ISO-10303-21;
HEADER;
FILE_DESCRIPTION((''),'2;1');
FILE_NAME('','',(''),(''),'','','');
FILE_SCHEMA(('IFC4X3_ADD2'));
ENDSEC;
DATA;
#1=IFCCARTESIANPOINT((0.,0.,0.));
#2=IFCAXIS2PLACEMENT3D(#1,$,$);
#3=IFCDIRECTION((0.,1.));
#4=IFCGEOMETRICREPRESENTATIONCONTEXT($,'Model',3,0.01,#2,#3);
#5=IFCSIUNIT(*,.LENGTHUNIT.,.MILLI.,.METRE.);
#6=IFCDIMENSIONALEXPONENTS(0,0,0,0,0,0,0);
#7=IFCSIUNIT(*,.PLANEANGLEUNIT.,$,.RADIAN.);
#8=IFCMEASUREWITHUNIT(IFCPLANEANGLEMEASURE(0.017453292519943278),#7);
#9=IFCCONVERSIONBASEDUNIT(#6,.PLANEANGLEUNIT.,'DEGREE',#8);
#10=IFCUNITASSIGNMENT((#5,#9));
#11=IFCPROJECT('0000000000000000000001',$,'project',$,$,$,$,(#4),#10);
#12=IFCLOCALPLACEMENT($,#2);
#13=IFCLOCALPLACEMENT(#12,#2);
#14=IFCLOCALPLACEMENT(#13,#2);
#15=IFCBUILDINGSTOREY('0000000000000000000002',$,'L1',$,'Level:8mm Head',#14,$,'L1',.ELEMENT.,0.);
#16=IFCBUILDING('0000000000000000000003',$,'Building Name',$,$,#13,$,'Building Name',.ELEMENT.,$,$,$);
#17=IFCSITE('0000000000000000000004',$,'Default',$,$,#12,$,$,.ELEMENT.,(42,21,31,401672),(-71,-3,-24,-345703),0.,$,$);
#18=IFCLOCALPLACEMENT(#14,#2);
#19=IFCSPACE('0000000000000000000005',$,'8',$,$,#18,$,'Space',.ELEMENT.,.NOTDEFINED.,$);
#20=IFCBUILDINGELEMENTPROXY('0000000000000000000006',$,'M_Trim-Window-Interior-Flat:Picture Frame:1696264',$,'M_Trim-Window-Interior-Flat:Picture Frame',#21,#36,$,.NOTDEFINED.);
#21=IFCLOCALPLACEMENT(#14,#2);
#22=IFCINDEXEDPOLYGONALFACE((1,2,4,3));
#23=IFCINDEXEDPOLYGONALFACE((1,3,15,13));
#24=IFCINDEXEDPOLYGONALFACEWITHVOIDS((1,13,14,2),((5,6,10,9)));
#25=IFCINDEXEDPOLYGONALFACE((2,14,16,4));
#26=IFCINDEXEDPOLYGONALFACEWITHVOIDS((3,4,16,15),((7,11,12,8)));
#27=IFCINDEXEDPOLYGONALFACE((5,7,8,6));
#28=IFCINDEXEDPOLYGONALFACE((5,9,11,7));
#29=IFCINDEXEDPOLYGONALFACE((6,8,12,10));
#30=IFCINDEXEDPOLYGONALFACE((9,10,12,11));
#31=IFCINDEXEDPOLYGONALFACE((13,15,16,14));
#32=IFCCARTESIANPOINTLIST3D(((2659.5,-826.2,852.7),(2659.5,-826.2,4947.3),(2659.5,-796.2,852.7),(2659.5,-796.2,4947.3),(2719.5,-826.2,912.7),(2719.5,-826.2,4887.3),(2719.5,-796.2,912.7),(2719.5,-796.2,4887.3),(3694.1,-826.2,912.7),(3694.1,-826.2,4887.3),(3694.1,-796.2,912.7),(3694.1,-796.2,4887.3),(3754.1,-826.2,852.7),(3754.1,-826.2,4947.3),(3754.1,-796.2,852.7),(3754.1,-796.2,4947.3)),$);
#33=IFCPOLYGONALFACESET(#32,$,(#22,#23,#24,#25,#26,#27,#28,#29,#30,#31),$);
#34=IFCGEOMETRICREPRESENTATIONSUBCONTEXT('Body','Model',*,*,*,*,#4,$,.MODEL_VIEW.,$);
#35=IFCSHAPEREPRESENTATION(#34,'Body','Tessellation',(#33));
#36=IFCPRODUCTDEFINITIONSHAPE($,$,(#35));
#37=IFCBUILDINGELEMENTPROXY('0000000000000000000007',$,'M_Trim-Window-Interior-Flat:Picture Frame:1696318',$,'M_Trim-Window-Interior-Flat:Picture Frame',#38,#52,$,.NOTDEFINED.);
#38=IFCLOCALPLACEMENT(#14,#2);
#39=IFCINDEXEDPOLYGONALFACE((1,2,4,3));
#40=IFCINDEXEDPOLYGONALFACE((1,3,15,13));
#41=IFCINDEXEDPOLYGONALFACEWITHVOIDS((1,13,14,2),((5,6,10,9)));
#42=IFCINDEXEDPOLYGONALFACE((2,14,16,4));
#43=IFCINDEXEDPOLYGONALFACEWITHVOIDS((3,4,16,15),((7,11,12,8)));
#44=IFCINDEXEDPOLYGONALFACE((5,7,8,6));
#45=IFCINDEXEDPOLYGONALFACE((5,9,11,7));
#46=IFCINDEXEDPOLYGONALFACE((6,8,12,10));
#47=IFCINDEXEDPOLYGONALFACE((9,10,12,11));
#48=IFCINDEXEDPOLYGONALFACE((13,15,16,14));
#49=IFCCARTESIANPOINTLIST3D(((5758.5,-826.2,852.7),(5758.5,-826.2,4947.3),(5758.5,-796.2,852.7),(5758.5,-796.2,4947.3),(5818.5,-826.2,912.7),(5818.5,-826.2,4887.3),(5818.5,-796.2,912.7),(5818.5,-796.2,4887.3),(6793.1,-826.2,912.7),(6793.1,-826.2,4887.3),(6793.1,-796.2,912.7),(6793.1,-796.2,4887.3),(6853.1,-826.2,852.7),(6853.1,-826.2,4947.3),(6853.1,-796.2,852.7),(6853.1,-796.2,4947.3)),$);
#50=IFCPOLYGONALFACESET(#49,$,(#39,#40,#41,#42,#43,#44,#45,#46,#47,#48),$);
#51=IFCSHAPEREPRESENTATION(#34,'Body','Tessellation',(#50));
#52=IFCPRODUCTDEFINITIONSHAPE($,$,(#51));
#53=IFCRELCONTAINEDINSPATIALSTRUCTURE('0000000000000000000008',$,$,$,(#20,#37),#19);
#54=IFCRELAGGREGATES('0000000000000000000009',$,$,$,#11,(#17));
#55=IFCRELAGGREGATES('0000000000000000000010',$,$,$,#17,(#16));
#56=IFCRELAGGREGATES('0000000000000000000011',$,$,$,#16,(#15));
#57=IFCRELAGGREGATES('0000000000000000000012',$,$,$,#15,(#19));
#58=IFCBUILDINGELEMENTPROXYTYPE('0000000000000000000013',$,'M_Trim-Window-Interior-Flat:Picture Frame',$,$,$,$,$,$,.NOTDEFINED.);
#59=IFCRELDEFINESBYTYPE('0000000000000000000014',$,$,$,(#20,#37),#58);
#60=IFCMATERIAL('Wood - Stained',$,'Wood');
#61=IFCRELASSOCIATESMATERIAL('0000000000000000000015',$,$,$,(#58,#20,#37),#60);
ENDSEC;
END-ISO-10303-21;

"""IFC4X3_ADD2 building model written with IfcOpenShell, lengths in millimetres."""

from ifc_helpers import new_model, entity, si_unit, converted_unit, direction, frame, origin, place, context, subcontext, project, spatial, polyline, outline, extrude, source, transform, mapped, material, type_object, type_shapes, element, save


model = new_model("IFC4X3_ADD2")

# Units and contexts
model_context = context("Model", 3, precision=0.01, world=origin(), true_north=direction((0.0, 1.0)))
body_context = subcontext(model_context, "Body", "Model", "MODEL_VIEW")
ifc_project = project(units=[si_unit("LENGTHUNIT", "METRE", prefix="MILLI"), converted_unit("PLANEANGLEUNIT", "DEGREE", entity("IfcPlaneAngleMeasure", 0.017453292519943278), si_unit("PLANEANGLEUNIT", "RADIAN"), dimensions=[0, 0, 0, 0, 0, 0, 0])], contexts=[model_context])

# Site, building, storey
site_placement = place(None, origin())
site = spatial("IfcSite", under=ifc_project, at=site_placement, Name="Default", CompositionType="ELEMENT", RefLatitude=(42, 21, 31, 401672), RefLongitude=(-71, -3, -24, -345703), RefElevation=0.0)
building_placement = place(site_placement, origin())
building = spatial("IfcBuilding", under=site, at=building_placement, Name="Building Name", LongName="Building Name", CompositionType="ELEMENT")
storey_placement = place(building_placement, origin())
storey = spatial("IfcBuildingStorey", under=building, at=storey_placement, Name="L1", ObjectType="Level:8mm Head", LongName="L1", CompositionType="ELEMENT", Elevation=0.0)

# Shared definitions
ifc_material_1 = material(Name="Wood - Stained", Category="Wood")

# Shared definitions
space_placement = place(storey_placement, origin())
space = spatial("IfcSpace", under=storey, at=space_placement, Name="8", LongName="Space", CompositionType="ELEMENT", PredefinedType="NOTDEFINED")

# Building element proxies
building_element_proxy_type_1 = type_object("IfcBuildingElementProxyType", Name="M_Trim-Window-Interior-Flat:Picture Frame", PredefinedType="NOTDEFINED", material=ifc_material_1)
shared_shape_1 = source(origin(), body_context, "Body", "SweptSolid", [
    extrude(outline(polyline([(-547.3, -2047.3), (547.3, -2047.3), (547.3, 2047.3), (-547.3, 2047.3), (-547.3, -2047.3)]), holes=[polyline([(-487.3, -1987.3), (-487.3, 1987.3), (487.3, 1987.3), (487.3, -1987.3), (-487.3, -1987.3)])]), frame((0.0, -2000.0, 0.0), z_axis=(0.0, 0.0, 1.0), x_axis=(-1.0, 0.0, 0.0)), (0.0, 0.0, 1.0), 30.0),
])
type_shapes(building_element_proxy_type_1, [shared_shape_1])
for number, where, z_axis, x_axis, name in (
    (1, (3206.8, -826.2, 4900.0), (0.0, 1.0, 0.0), (-1.0, 0.0, 0.0), "M_Trim-Window-Interior-Flat:Picture Frame:1696264"),
    (2, (6305.8, -826.2, 4900.0), (0.0, 1.0, 0.0), (-1.0, 0.0, 0.0), "M_Trim-Window-Interior-Flat:Picture Frame:1696318"),
):
    element("IfcBuildingElementProxy", number, at=place(space_placement, frame(where, z_axis=z_axis, x_axis=x_axis)), inside=space, type_object=building_element_proxy_type_1, material=ifc_material_1, Name=name, ObjectType="M_Trim-Window-Interior-Flat:Picture Frame", PredefinedType="NOTDEFINED", context=body_context, shape_type="MappedRepresentation", body=[
        mapped(shared_shape_1, transform((0.0, 0.0, 0.0), scale=1.0)),
    ])

save(model, "model.ifc")
